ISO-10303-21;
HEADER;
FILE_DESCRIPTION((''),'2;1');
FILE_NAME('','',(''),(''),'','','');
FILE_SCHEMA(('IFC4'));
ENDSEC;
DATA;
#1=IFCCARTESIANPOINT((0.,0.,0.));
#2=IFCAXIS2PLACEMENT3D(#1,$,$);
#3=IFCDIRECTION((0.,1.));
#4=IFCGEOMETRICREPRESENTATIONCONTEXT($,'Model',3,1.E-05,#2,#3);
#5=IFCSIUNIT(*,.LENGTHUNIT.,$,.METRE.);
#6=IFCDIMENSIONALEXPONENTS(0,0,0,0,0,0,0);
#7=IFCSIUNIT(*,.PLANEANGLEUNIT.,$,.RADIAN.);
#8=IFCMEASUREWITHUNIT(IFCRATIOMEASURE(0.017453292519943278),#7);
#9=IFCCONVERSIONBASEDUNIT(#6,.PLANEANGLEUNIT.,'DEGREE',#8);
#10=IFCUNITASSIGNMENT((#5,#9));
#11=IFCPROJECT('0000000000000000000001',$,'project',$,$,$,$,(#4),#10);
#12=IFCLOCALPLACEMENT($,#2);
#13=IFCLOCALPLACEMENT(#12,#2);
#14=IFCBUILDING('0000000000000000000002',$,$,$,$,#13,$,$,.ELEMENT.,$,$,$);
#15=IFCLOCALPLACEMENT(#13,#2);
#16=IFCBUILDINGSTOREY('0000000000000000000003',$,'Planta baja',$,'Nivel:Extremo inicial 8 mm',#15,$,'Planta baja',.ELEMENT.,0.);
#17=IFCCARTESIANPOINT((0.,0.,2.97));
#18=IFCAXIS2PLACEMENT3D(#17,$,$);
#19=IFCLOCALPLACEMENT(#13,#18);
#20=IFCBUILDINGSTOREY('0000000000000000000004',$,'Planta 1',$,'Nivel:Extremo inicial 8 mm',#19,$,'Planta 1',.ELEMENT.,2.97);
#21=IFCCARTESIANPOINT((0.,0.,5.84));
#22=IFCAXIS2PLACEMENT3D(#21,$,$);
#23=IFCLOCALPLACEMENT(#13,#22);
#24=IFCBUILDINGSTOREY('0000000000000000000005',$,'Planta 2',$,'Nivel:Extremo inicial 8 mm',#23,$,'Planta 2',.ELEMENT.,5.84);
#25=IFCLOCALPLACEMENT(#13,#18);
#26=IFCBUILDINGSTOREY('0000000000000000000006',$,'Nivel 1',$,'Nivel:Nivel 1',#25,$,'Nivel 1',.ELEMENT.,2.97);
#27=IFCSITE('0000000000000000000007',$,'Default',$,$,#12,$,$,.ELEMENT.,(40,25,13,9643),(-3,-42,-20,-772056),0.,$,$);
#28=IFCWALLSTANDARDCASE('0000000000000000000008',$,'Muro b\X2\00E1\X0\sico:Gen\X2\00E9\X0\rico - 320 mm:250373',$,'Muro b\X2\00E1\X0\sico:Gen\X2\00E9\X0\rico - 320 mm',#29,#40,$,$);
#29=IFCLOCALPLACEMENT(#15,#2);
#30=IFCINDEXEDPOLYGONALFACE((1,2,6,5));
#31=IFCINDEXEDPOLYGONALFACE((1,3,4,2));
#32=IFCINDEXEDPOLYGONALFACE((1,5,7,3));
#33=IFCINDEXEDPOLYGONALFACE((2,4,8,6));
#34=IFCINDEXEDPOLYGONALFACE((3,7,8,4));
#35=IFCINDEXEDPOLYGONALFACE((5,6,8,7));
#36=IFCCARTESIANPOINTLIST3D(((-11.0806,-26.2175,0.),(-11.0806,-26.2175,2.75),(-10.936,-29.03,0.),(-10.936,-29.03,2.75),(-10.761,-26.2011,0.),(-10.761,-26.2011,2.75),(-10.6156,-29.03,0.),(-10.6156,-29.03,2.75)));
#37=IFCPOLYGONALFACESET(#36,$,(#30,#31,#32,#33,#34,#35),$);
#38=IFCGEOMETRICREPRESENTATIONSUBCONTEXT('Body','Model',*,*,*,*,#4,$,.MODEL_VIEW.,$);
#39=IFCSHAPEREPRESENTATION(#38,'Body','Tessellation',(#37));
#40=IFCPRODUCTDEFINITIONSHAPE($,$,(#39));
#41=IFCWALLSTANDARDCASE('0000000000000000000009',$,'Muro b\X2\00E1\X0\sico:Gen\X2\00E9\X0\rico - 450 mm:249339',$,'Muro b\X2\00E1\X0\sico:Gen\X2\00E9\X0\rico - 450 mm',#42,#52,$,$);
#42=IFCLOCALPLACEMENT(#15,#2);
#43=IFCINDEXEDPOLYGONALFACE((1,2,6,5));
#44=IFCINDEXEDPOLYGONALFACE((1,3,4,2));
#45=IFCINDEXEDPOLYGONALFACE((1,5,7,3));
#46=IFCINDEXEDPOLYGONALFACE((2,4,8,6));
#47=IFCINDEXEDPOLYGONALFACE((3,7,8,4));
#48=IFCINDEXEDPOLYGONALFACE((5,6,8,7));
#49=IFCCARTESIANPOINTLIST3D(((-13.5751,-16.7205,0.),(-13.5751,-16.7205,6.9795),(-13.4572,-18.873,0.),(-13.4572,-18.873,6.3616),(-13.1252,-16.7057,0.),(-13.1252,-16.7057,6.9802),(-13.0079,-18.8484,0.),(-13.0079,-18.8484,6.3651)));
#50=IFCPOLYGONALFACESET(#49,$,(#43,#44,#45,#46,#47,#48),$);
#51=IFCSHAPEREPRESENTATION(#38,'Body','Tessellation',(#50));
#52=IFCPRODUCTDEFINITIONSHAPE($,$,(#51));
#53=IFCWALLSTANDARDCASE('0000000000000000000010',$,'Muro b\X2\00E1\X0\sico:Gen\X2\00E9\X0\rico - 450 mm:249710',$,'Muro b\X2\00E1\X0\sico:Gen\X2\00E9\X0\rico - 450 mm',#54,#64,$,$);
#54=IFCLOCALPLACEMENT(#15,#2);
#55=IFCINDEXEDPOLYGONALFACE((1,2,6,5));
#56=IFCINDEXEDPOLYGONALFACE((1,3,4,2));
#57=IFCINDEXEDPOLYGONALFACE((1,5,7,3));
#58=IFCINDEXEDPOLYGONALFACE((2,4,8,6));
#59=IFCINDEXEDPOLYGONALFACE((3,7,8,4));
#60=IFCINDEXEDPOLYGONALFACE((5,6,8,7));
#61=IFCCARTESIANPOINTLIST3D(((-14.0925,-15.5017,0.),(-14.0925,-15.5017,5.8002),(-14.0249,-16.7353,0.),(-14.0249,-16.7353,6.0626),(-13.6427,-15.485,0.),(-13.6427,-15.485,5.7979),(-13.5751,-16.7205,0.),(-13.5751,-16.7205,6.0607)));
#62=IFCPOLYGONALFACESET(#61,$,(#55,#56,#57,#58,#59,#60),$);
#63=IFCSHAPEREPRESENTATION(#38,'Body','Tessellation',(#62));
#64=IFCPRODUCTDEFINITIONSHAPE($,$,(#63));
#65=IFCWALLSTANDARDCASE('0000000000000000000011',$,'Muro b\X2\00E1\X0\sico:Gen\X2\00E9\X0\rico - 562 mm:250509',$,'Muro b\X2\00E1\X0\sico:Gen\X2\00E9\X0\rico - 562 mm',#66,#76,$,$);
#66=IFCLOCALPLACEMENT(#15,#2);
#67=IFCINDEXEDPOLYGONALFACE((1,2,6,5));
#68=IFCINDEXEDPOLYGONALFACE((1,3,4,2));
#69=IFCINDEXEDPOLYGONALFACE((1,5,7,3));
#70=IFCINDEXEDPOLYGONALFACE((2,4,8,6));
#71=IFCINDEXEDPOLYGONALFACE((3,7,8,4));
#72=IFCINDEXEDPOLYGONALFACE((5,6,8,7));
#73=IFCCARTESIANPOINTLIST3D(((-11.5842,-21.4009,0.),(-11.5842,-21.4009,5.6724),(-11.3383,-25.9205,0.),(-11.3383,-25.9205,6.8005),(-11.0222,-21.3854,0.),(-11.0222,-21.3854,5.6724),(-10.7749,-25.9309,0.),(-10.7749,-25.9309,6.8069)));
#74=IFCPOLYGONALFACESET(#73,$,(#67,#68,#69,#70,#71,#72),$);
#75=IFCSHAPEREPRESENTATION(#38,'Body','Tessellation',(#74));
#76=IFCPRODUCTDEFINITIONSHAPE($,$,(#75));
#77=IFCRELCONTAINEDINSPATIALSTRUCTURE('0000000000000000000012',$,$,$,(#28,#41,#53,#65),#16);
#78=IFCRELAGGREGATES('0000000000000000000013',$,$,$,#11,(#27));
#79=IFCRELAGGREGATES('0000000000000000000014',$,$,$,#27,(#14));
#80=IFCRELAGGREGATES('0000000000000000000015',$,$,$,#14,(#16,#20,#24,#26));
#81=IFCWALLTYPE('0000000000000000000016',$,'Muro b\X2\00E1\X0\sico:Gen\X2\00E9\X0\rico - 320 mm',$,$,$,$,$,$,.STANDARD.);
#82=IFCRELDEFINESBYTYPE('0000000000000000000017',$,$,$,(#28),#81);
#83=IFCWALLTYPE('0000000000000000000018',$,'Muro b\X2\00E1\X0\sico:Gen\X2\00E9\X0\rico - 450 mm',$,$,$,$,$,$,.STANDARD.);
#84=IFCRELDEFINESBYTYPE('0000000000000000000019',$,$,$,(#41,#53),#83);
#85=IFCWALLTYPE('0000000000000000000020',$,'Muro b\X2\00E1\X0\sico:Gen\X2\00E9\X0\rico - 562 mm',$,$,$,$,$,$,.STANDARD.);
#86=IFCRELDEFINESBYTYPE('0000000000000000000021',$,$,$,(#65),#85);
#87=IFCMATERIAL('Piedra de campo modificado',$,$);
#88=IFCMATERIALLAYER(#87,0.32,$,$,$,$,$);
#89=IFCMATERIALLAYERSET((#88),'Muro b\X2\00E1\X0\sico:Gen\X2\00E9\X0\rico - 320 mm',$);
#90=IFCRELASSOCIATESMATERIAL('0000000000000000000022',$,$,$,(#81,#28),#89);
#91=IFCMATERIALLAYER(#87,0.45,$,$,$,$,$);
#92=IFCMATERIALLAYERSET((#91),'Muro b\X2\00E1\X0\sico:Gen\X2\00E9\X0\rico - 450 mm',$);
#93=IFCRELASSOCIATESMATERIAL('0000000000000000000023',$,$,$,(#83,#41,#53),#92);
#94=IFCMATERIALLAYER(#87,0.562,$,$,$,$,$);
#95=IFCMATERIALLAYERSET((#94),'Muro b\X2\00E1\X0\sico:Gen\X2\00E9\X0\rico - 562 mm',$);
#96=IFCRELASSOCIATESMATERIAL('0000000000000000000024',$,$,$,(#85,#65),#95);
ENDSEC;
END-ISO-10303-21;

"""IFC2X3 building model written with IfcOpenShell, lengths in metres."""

from ifc_helpers import new_model, entity, si_unit, converted_unit, direction, frame, origin, place, context, subcontext, project, spatial, polyline, outline, extrude, clip, bounded_halfspace, material, layer, layer_set, layer_usage, type_object, element, save


model = new_model("IFC2X3")

# Units and contexts
model_context = context("Model", 3, precision=1e-05, world=origin(), true_north=direction((0.0, 1.0)))
body_context = subcontext(model_context, "Body", "Model", "MODEL_VIEW")
ifc_project = project(units=[si_unit("LENGTHUNIT", "METRE"), converted_unit("PLANEANGLEUNIT", "DEGREE", entity("IfcRatioMeasure", 0.017453292519943278), si_unit("PLANEANGLEUNIT", "RADIAN"), dimensions=[0, 0, 0, 0, 0, 0, 0])], contexts=[model_context])

# Site, building, storey
site_placement = place(None, origin())
site = spatial("IfcSite", under=ifc_project, at=site_placement, Name="Default", CompositionType="ELEMENT", RefLatitude=(40, 25, 13, 9643), RefLongitude=(-3, -42, -20, -772056), RefElevation=0.0)
building_placement = place(site_placement, origin())
building = spatial("IfcBuilding", under=site, at=building_placement, CompositionType="ELEMENT")
storey_1_placement = place(building_placement, origin())
storey_1 = spatial("IfcBuildingStorey", under=building, at=storey_1_placement, Name="Planta baja", ObjectType="Nivel:Extremo inicial 8 mm", LongName="Planta baja", CompositionType="ELEMENT", Elevation=0.0)

# Wall
ifc_material_1 = material(Name="Piedra de campo modificado")
ifc_layer_1 = layer(ifc_material_1, 0.32)
ifc_layer_set_1 = layer_set([ifc_layer_1], Name="Muro básico:Genérico - 320 mm")
ifc_layer_usage_1 = layer_usage(ifc_layer_set_1, "AXIS2", "NEGATIVE", 0.16)
wall_type_1 = type_object("IfcWallType", Name="Muro básico:Genérico - 320 mm", PredefinedType="STANDARD", material=ifc_layer_set_1)
wall_1_placement = place(storey_1_placement, frame((-10.7753, -29.0382, 0.0), z_axis=(0.0, 0.0, 1.0), x_axis=(-0.051364, 0.99868, 0.0)))
element("IfcWallStandardCase", 1, at=wall_1_placement, inside=storey_1, type_object=wall_type_1, material=ifc_layer_usage_1, Name="Muro básico:Genérico - 320 mm:250373", ObjectType="Muro básico:Genérico - 320 mm", context=body_context, shape_type="SweptSolid", body=[
    extrude(outline(polyline([(2.8327, -0.16), (2.8327, 0.16), (0.0165, 0.16), (0.0, -0.16), (2.8327, -0.16)])), origin(), (0.0, 0.0, 1.0), 2.75),
])

# Shared definitions
ifc_layer_2 = layer(ifc_material_1, 0.45)
ifc_layer_set_2 = layer_set([ifc_layer_2], Name="Muro básico:Genérico - 450 mm")
ifc_layer_usage_2 = layer_usage(ifc_layer_set_2, "AXIS2", "NEGATIVE", 0.225)
wall_type_2 = type_object("IfcWallType", Name="Muro básico:Genérico - 450 mm", PredefinedType="STANDARD", material=ifc_layer_set_2)

# Shared definitions
storey_2_placement = place(building_placement, frame((0.0, 0.0, 2.97)))
storey_2 = spatial("IfcBuildingStorey", under=building, at=storey_2_placement, Name="Planta 1", ObjectType="Nivel:Extremo inicial 8 mm", LongName="Planta 1", CompositionType="ELEMENT", Elevation=2.97)

# Shared definitions
storey_3_placement = place(building_placement, frame((0.0, 0.0, 5.84)))
storey_3 = spatial("IfcBuildingStorey", under=building, at=storey_3_placement, Name="Planta 2", ObjectType="Nivel:Extremo inicial 8 mm", LongName="Planta 2", CompositionType="ELEMENT", Elevation=5.84)

# Walls
wall_2_placement = place(storey_1_placement, frame((-13.3504, -16.7082, 0.0), z_axis=(0.0, 0.0, 1.0), x_axis=(0.054661, -0.998505, 0.0)))
element("IfcWallStandardCase", 2, at=wall_2_placement, inside=storey_1, type_object=wall_type_2, material=ifc_layer_usage_2, Name="Muro básico:Genérico - 450 mm:249339", ObjectType="Muro básico:Genérico - 450 mm", context=body_context, shape_type="Clipping", body=[
    clip(extrude(outline(polyline([(2.1557, -0.225), (2.1557, 0.225), (0.0098, 0.225), (0.0, -0.225), (2.1557, -0.225)])), origin(), (0.0, 0.0, 1.0), 6.9802), bounded_halfspace(frame((0.0, -0.225, 6.9795), z_axis=(0.275536, -0.007488, 0.961262), x_axis=(0.027168, 0.999631, 0.0)), False, frame((0.0, -0.225, 6.9795)), polyline([(0.0, 0.0), (2.1557, 0.0), (2.1557, 0.45), (0.0098, 0.45), (0.0, 0.0)]))),
])
wall_3_placement = place(storey_1_placement, frame((-13.7997, -16.7328, 0.0), z_axis=(0.0, 0.0, 1.0), x_axis=(-0.054661, 0.998505, 0.0)))
element("IfcWallStandardCase", 3, at=wall_3_placement, inside=storey_1, type_object=wall_type_2, material=ifc_layer_usage_2, Name="Muro básico:Genérico - 450 mm:249710", ObjectType="Muro básico:Genérico - 450 mm", context=body_context, shape_type="Clipping", body=[
    clip(extrude(outline(polyline([(1.2373, -0.225), (1.2452, 0.225), (0.0098, 0.225), (0.0, -0.225), (1.2373, -0.225)])), origin(), (0.0, 0.0, 1.0), 6.0626), bounded_halfspace(frame((0.0, -0.225, 6.0607), z_axis=(0.207732, -0.008646, 0.978148), x_axis=(0.041585, 0.999135, 0.0)), False, frame((0.0, -0.225, 6.0607)), polyline([(0.0, 0.0), (1.2373, 0.0), (1.2452, 0.45), (0.0098, 0.45), (0.0, 0.0)]))),
])

# Shared definitions
storey_4_placement = place(building_placement, frame((0.0, 0.0, 2.97)))
storey_4 = spatial("IfcBuildingStorey", under=building, at=storey_4_placement, Name="Nivel 1", ObjectType="Nivel:Nivel 1", LongName="Nivel 1", CompositionType="ELEMENT", Elevation=2.97)

# Wall
ifc_layer_3 = layer(ifc_material_1, 0.562)
ifc_layer_set_3 = layer_set([ifc_layer_3], Name="Muro básico:Genérico - 562 mm")
ifc_layer_usage_3 = layer_usage(ifc_layer_set_3, "AXIS2", "NEGATIVE", 0.281)
wall_type_3 = type_object("IfcWallType", Name="Muro básico:Genérico - 562 mm", PredefinedType="STANDARD", material=ifc_layer_set_3)
wall_4_placement = place(storey_1_placement, frame((-11.0555, -25.9462, 0.0), z_axis=(0.0, 0.0, 1.0), x_axis=(-0.05431, 0.998524, 0.0)))
element("IfcWallStandardCase", 4, at=wall_4_placement, inside=storey_1, type_object=wall_type_3, material=ifc_layer_usage_3, Name="Muro básico:Genérico - 562 mm:250509", ObjectType="Muro básico:Genérico - 562 mm", context=body_context, shape_type="Clipping", body=[
    clip(extrude(outline(polyline([(4.5522, -0.281), (4.5673, 0.281), (0.041, 0.281), (0.0, -0.281), (4.5522, -0.281)])), origin(), (0.0, 0.0, 1.0), 6.8069), bounded_halfspace(frame((0.0, -0.281, 6.8069), z_axis=(0.241835, -0.006488, 0.970296), x_axis=(0.026817, 0.99964, 0.0)), False, frame((0.0, -0.281, 6.8069)), polyline([(0.0, 0.0), (4.5522, 0.0), (4.5673, 0.562), (0.041, 0.562), (0.0, 0.0)]))),
])

save(model, "model.ifc")
